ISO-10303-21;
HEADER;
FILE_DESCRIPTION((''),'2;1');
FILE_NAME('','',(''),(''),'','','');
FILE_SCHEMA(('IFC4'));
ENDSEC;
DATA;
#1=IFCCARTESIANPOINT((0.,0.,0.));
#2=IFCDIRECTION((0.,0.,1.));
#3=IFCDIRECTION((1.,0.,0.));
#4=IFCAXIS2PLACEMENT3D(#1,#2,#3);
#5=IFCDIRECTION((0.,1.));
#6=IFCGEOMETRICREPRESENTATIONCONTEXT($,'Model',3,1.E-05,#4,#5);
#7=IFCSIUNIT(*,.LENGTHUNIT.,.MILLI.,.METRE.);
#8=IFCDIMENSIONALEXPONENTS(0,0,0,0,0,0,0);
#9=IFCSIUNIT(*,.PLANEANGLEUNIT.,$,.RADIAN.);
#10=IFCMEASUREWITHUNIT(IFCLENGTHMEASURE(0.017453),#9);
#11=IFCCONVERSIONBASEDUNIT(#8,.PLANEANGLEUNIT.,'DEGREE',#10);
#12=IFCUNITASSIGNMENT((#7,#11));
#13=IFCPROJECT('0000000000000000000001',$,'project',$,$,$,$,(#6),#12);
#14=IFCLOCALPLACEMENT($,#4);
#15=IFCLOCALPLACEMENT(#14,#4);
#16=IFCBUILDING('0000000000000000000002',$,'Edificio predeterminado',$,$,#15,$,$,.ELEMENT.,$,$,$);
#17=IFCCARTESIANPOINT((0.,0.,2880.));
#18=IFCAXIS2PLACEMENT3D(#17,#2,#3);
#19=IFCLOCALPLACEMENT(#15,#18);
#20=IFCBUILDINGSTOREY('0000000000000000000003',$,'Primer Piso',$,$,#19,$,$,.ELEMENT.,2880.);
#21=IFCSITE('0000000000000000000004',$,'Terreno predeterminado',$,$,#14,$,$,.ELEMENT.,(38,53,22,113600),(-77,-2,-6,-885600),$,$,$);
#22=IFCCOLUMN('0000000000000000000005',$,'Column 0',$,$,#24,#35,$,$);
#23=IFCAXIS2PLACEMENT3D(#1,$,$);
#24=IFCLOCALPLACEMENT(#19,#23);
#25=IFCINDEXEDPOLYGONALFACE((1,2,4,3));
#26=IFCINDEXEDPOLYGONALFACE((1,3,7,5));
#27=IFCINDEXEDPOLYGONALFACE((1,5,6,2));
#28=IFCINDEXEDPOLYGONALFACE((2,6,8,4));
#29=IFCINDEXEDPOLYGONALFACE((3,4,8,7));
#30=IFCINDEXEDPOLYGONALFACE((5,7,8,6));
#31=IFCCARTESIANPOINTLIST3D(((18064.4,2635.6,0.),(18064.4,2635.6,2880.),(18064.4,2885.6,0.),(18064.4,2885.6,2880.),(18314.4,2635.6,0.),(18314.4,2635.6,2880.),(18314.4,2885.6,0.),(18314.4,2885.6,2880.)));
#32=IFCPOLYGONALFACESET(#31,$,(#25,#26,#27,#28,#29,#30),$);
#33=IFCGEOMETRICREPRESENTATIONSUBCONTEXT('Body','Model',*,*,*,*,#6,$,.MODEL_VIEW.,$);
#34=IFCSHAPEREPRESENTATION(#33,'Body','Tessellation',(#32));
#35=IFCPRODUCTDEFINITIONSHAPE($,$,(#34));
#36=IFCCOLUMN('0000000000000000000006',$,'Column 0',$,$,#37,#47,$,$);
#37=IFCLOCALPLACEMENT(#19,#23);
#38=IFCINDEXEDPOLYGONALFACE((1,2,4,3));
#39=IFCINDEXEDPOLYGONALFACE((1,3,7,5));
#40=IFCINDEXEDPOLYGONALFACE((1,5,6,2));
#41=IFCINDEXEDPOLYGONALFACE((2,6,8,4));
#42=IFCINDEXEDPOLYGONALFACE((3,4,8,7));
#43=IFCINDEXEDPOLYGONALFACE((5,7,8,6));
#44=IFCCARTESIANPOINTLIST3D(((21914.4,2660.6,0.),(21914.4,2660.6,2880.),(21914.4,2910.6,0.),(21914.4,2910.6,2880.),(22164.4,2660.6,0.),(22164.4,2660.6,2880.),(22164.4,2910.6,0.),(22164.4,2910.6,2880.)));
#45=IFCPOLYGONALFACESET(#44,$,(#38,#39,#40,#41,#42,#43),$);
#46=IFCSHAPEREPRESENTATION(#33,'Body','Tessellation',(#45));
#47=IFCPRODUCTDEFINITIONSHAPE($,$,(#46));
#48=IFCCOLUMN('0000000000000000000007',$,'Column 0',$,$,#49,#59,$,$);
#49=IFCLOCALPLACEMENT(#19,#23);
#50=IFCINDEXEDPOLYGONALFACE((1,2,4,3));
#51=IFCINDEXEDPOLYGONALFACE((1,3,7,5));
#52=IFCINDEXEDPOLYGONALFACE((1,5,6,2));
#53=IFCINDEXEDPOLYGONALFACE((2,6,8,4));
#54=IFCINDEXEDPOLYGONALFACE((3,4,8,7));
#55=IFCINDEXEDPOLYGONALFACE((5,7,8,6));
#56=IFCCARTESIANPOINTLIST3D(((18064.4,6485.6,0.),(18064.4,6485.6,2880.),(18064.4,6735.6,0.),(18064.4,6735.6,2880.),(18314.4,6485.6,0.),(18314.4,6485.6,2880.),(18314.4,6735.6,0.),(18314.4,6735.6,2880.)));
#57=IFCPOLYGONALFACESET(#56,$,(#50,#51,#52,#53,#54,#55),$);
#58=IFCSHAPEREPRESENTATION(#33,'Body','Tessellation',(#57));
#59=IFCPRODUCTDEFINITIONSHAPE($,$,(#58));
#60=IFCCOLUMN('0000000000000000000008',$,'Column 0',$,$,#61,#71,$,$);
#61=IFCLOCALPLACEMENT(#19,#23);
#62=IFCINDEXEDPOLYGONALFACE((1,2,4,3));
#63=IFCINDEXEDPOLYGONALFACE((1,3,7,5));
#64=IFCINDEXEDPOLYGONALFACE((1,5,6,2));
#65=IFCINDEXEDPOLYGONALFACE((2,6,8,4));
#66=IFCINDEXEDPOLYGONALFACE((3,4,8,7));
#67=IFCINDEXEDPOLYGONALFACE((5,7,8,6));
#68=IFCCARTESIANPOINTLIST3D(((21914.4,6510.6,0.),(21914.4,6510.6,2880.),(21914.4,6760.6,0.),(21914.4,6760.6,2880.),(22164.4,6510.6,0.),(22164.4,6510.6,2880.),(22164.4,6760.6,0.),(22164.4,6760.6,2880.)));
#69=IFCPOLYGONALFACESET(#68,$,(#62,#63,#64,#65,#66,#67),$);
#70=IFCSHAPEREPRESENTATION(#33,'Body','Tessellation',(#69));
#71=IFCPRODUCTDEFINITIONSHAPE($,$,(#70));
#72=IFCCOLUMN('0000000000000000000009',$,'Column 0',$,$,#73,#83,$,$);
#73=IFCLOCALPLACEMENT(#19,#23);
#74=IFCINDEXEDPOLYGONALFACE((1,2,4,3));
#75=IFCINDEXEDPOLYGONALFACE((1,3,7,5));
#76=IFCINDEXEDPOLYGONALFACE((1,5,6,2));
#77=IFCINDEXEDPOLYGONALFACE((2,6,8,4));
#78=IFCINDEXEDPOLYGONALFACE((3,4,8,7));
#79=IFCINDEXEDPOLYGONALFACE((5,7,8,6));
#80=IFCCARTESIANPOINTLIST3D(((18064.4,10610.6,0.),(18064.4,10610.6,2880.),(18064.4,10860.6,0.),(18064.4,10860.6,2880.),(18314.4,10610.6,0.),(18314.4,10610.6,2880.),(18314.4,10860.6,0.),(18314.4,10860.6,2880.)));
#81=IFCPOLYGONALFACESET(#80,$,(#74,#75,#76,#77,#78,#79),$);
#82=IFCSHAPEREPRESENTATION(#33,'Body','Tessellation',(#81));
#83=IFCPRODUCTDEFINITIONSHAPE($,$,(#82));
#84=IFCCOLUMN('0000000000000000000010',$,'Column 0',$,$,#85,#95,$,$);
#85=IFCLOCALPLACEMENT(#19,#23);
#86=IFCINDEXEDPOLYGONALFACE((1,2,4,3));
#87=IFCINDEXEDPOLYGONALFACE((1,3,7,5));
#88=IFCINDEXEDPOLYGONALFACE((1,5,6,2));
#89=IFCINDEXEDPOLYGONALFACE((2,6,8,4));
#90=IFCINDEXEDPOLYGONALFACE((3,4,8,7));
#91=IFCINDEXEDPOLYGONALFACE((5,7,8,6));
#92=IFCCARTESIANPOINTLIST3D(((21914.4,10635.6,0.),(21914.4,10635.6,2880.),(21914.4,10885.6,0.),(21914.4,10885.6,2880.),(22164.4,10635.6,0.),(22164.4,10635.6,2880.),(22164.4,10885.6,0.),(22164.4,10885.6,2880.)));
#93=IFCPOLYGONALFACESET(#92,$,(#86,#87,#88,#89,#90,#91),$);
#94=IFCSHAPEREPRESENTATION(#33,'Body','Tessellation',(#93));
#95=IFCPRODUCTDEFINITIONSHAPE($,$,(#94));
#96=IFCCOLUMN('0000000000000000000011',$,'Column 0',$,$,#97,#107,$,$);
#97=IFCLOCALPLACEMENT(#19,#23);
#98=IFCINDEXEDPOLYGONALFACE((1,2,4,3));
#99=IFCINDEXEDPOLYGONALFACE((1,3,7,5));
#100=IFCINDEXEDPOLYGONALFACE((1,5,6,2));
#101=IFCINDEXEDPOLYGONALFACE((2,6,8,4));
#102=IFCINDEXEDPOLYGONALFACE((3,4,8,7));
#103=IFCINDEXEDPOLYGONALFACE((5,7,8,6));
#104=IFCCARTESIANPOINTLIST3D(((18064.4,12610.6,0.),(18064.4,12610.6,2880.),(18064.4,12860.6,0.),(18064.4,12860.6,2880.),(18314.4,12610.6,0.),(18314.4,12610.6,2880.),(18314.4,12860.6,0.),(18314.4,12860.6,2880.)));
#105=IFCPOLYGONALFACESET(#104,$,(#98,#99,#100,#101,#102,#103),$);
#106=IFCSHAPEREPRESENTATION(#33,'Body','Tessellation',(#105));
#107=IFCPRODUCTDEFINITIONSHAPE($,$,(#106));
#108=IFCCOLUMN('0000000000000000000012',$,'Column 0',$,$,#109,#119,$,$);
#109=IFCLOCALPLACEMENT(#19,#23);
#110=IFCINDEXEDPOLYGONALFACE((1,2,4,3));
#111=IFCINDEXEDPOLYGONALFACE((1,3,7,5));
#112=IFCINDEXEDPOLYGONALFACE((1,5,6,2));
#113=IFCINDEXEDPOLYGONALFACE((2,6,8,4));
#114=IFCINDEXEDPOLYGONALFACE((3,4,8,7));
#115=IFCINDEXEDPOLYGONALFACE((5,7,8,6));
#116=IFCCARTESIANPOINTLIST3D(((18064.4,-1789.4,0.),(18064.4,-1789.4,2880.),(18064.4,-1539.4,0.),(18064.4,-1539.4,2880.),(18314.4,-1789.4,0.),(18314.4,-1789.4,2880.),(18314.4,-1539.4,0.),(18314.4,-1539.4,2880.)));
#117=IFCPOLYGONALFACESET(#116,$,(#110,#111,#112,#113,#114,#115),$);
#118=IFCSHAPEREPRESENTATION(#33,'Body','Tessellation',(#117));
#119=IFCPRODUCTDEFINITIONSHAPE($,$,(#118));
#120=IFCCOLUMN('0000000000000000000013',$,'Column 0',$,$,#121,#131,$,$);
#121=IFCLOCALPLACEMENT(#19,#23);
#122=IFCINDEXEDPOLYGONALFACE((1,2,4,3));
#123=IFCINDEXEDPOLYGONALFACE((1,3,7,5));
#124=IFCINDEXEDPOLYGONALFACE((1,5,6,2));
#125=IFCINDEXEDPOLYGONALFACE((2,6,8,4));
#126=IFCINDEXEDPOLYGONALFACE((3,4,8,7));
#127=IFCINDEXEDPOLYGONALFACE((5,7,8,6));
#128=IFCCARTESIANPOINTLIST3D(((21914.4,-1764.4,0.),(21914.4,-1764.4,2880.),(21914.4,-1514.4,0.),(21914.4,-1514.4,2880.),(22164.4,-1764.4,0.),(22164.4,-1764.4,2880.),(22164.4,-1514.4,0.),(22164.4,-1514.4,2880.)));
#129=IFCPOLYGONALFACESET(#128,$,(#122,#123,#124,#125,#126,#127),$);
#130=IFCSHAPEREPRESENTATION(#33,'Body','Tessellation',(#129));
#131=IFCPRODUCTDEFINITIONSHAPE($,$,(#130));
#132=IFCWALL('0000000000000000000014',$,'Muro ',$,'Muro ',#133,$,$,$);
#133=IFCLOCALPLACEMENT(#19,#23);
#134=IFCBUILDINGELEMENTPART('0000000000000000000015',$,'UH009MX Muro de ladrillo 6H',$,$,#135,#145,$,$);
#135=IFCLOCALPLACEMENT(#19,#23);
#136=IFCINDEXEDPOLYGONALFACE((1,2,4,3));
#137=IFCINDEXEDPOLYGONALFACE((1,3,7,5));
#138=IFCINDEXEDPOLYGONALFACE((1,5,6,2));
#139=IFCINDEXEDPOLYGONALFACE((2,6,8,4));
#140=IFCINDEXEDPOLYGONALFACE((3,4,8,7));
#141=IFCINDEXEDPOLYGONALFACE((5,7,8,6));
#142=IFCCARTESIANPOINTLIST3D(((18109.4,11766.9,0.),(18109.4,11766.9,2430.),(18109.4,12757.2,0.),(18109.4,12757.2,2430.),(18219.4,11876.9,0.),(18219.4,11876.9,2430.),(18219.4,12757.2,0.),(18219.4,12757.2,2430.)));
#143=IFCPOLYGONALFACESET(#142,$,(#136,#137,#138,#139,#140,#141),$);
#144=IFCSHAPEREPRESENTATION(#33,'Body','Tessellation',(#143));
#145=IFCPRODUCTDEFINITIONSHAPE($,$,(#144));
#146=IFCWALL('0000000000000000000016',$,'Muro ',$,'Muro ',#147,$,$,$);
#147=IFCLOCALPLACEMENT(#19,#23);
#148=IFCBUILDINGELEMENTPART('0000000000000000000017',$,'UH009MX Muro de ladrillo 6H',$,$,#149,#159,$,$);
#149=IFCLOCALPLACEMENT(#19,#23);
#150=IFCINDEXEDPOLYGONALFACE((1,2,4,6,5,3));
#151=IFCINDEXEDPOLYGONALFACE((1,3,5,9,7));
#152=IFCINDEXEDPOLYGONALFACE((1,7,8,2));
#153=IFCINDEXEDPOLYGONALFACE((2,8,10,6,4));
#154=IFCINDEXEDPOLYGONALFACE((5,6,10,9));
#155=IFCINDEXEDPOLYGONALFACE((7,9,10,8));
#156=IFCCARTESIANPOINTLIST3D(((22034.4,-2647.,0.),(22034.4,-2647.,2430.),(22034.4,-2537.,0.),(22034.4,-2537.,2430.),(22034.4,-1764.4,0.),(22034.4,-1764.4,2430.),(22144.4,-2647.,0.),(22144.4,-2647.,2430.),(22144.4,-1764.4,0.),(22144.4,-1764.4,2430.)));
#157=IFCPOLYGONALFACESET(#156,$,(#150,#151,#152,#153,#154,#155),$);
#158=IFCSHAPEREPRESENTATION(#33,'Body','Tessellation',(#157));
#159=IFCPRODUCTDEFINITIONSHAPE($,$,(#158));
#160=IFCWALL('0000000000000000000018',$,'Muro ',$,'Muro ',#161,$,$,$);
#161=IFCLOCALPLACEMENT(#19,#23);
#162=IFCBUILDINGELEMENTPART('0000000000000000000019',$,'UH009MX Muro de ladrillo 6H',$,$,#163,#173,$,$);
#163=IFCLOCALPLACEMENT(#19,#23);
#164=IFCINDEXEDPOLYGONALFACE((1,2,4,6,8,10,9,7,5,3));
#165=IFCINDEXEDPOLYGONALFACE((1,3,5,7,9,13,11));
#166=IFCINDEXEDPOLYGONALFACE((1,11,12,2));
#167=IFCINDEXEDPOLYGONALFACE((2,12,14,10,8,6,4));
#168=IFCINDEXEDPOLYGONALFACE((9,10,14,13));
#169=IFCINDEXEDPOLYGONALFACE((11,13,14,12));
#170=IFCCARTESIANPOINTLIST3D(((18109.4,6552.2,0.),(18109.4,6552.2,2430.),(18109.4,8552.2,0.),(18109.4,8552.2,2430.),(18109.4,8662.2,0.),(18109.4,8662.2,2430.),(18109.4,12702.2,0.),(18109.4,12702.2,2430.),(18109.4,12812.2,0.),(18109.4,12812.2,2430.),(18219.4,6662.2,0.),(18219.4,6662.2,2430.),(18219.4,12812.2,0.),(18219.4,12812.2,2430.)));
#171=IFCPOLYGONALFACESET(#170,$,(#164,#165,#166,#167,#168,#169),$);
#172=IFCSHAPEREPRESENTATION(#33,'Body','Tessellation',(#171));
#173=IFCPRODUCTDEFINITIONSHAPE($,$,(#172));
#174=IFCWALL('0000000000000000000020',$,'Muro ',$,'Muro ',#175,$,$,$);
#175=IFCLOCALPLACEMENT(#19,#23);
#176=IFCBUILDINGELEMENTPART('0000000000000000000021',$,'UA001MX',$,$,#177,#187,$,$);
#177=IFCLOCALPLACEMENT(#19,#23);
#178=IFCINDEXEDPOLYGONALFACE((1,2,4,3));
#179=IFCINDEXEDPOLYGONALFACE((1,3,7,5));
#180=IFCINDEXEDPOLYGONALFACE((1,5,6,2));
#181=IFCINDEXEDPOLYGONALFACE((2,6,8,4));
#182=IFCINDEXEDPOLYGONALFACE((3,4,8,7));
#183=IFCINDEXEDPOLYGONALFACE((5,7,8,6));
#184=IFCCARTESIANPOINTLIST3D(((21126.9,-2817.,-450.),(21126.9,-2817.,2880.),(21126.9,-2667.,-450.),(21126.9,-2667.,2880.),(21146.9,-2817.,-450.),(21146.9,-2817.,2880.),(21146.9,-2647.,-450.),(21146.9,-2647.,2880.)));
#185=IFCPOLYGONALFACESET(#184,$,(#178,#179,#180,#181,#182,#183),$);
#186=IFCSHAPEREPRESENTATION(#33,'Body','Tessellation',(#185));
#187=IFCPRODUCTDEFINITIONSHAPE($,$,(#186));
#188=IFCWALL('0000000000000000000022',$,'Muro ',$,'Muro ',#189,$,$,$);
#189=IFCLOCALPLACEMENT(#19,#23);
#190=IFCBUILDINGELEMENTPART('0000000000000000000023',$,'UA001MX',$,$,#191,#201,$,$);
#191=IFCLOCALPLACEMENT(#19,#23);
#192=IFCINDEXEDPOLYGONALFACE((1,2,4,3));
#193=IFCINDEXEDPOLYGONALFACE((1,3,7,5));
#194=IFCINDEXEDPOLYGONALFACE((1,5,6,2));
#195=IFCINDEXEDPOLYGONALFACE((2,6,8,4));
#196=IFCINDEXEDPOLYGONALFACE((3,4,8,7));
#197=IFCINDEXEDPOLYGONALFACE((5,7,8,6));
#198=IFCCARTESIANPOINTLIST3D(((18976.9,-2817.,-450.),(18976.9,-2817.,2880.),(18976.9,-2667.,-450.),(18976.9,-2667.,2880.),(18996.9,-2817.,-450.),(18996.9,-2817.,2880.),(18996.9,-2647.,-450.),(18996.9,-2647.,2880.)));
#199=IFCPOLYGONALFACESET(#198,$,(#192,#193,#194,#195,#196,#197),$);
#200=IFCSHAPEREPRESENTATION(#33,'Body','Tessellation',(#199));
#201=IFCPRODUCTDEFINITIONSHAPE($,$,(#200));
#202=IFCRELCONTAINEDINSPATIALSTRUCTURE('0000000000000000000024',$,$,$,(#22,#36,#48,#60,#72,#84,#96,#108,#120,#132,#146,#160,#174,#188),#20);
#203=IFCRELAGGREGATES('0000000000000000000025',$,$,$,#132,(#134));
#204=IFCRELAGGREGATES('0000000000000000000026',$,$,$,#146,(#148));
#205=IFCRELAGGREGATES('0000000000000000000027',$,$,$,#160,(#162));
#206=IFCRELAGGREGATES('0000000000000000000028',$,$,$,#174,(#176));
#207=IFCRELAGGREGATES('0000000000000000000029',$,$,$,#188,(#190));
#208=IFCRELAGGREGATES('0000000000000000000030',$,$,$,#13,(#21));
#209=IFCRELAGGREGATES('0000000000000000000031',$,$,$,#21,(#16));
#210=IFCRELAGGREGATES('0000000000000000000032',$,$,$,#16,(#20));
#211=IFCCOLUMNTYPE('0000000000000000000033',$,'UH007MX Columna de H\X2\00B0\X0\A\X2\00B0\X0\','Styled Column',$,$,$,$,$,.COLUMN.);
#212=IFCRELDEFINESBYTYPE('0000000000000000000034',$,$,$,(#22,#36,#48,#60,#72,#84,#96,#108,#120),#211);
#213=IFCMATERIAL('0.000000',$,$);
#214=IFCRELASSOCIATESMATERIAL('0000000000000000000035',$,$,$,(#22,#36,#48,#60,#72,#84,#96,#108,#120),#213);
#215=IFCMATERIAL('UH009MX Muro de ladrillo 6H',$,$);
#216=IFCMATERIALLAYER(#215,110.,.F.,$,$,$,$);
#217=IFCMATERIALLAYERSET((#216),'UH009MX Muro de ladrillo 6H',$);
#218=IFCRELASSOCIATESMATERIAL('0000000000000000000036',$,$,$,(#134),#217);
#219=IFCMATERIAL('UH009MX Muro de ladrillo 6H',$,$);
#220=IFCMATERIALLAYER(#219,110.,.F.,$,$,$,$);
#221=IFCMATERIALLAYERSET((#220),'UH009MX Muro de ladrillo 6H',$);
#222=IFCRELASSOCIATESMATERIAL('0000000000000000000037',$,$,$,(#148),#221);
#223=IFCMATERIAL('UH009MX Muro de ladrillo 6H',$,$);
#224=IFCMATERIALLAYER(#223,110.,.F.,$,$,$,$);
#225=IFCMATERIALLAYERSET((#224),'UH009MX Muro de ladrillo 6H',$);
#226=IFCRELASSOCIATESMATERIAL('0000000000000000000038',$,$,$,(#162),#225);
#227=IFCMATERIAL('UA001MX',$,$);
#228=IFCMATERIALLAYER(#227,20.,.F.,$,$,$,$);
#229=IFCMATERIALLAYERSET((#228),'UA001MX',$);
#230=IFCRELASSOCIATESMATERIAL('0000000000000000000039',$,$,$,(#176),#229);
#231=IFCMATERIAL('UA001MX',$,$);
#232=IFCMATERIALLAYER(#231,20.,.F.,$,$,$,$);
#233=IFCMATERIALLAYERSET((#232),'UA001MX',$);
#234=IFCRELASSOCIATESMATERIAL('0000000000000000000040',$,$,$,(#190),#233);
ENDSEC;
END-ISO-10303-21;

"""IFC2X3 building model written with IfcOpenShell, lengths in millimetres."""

from ifc_helpers import new_model, entity, si_unit, converted_unit, direction, frame, origin_with_axes, place, context, subcontext, project, spatial, polyline, outline, extrude, clip, bounded_halfspace, material, layer, layer_set, layer_usage, type_object, element, aggregate, save


model = new_model("IFC2X3")

# Units and contexts
model_context = context("Model", 3, precision=1e-05, world=origin_with_axes(), true_north=direction((0.0, 1.0)))
body_context = subcontext(model_context, "Body", "Model", "MODEL_VIEW")
ifc_project = project(units=[si_unit("LENGTHUNIT", "METRE", prefix="MILLI"), converted_unit("PLANEANGLEUNIT", "DEGREE", entity("IfcLengthMeasure", 0.017453), si_unit("PLANEANGLEUNIT", "RADIAN"), dimensions=[0, 0, 0, 0, 0, 0, 0])], contexts=[model_context])

# Site, building, storey
site_placement = place(None, origin_with_axes())
site = spatial("IfcSite", under=ifc_project, at=site_placement, Name="Terreno predeterminado", CompositionType="ELEMENT", RefLatitude=(38, 53, 22, 113600), RefLongitude=(-77, -2, -6, -885600))
building_placement = place(site_placement, origin_with_axes())
building = spatial("IfcBuilding", under=site, at=building_placement, Name="Edificio predeterminado", CompositionType="ELEMENT")
storey_placement = place(building_placement, frame((0.0, 0.0, 2880.0), z_axis=(0.0, 0.0, 1.0), x_axis=(1.0, 0.0, 0.0)))
storey = spatial("IfcBuildingStorey", under=building, at=storey_placement, Name="Primer Piso", CompositionType="ELEMENT", Elevation=2880.0)

# Columns
ifc_material_1 = material(Name="0.000000")
column_type = type_object("IfcColumnType", Name="UH007MX Columna de H°A°", Description="Styled Column", PredefinedType="COLUMN")
for number, where, z_axis, x_axis, name in (
    (1, (18189.4, 2760.6, 0.0), (0.0, 0.0, 1.0), (1.0, 0.0, 0.0), "Column 0"),
    (2, (22039.4, 2785.6, 0.0), (0.0, 0.0, 1.0), (1.0, 0.0, 0.0), "Column 0"),
    (3, (18189.4, 6610.6, 0.0), (0.0, 0.0, 1.0), (1.0, 0.0, 0.0), "Column 0"),
    (4, (22039.4, 6635.6, 0.0), (0.0, 0.0, 1.0), (1.0, 0.0, 0.0), "Column 0"),
    (5, (18189.4, 10735.6, 0.0), (0.0, 0.0, 1.0), (1.0, 0.0, 0.0), "Column 0"),
    (6, (22039.4, 10760.6, 0.0), (0.0, 0.0, 1.0), (1.0, 0.0, 0.0), "Column 0"),
    (7, (18189.4, 12735.6, 0.0), (0.0, 0.0, 1.0), (1.0, 0.0, 0.0), "Column 0"),
    (8, (18189.4, -1664.4, 0.0), (0.0, 0.0, 1.0), (1.0, 0.0, 0.0), "Column 0"),
    (9, (22039.4, -1639.4, 0.0), (0.0, 0.0, 1.0), (1.0, 0.0, 0.0), "Column 0"),
):
    element("IfcColumn", number, at=place(storey_placement, frame(where, z_axis=z_axis, x_axis=x_axis)), inside=storey, type_object=column_type, material=ifc_material_1, Name=name, context=body_context, shape_type="SweptSolid", body=[
        extrude(outline(polyline([(-125.0, -125.0), (125.0, -125.0), (125.0, 125.0), (-125.0, 125.0), (-125.0, -125.0)])), origin_with_axes(), (0.0, 0.0, 1.0), 2880.0),
    ])

# Walls, building element parts
wall_1_placement = place(storey_placement, frame((18164.4, 11821.9, 0.0), z_axis=(0.0, 0.0, 1.0), x_axis=(0.0, 1.0, 0.0)))
wall_1 = element("IfcWall", 10, at=wall_1_placement, inside=storey, Name="Muro ", ObjectType="Muro ")
ifc_material_2 = material(Name="UH009MX Muro de ladrillo 6H")
ifc_layer_1 = layer(ifc_material_2, 110.0, ventilated=False)
ifc_layer_set_1 = layer_set([ifc_layer_1], Name="UH009MX Muro de ladrillo 6H")
ifc_layer_usage_1 = layer_usage(ifc_layer_set_1, "AXIS2", "NEGATIVE", -55.0)
building_element_part_1_placement = place(wall_1_placement, origin_with_axes())
building_element_part_1 = element("IfcBuildingElementPart", 11, at=building_element_part_1_placement, material=ifc_layer_usage_1, Name="UH009MX Muro de ladrillo 6H", context=body_context, shape_type="SweptSolid", body=[
    extrude(outline(polyline([(935.2, 55.0), (935.2, -55.0), (55.0, -55.0), (-55.0, 55.0), (935.2, 55.0)])), origin_with_axes(), (0.0, 0.0, 1.0), 2430.0),
])
aggregate(wall_1, [building_element_part_1])
wall_2_placement = place(storey_placement, frame((22089.4, -1764.4, 0.0), z_axis=(0.0, 0.0, 1.0), x_axis=(0.0, -1.0, 0.0)))
wall_2 = element("IfcWall", 12, at=wall_2_placement, inside=storey, Name="Muro ", ObjectType="Muro ")
ifc_material_3 = material(Name="UH009MX Muro de ladrillo 6H")
ifc_layer_2 = layer(ifc_material_3, 110.0, ventilated=False)
ifc_layer_set_2 = layer_set([ifc_layer_2], Name="UH009MX Muro de ladrillo 6H")
ifc_layer_usage_2 = layer_usage(ifc_layer_set_2, "AXIS2", "NEGATIVE", -55.0)
building_element_part_2_placement = place(wall_2_placement, origin_with_axes())
building_element_part_2 = element("IfcBuildingElementPart", 13, at=building_element_part_2_placement, material=ifc_layer_usage_2, Name="UH009MX Muro de ladrillo 6H", context=body_context, shape_type="SweptSolid", body=[
    extrude(outline(polyline([(882.6, 55.0), (882.6, -55.0), (772.6, -55.0), (0.0, -55.0), (0.0, 55.0), (882.6, 55.0)])), origin_with_axes(), (0.0, 0.0, 1.0), 2430.0),
])
aggregate(wall_2, [building_element_part_2])
wall_3_placement = place(storey_placement, frame((18164.4, 12757.2, 0.0), z_axis=(0.0, 0.0, 1.0), x_axis=(0.0, -1.0, 0.0)))
wall_3 = element("IfcWall", 14, at=wall_3_placement, inside=storey, Name="Muro ", ObjectType="Muro ")
ifc_material_4 = material(Name="UH009MX Muro de ladrillo 6H")
ifc_layer_3 = layer(ifc_material_4, 110.0, ventilated=False)
ifc_layer_set_3 = layer_set([ifc_layer_3], Name="UH009MX Muro de ladrillo 6H")
ifc_layer_usage_3 = layer_usage(ifc_layer_set_3, "AXIS2", "NEGATIVE", -55.0)
building_element_part_3_placement = place(wall_3_placement, origin_with_axes())
building_element_part_3 = element("IfcBuildingElementPart", 15, at=building_element_part_3_placement, material=ifc_layer_usage_3, Name="UH009MX Muro de ladrillo 6H", context=body_context, shape_type="SweptSolid", body=[
    extrude(outline(polyline([(6095.0, 55.0), (6205.0, -55.0), (4205.0, -55.0), (4095.0, -55.0), (55.0, -55.0), (-55.0, -55.0), (-55.0, 55.0), (6095.0, 55.0)])), origin_with_axes(), (0.0, 0.0, 1.0), 2430.0),
])
aggregate(wall_3, [building_element_part_3])
wall_4_placement = place(storey_placement, frame((21201.9, -2817.0, 0.0), z_axis=(0.0, 0.0, 1.0), x_axis=(0.0, 1.0, 0.0)))
wall_4 = element("IfcWall", 16, at=wall_4_placement, inside=storey, Name="Muro ", ObjectType="Muro ")
ifc_material_5 = material(Name="UA001MX")
ifc_layer_4 = layer(ifc_material_5, 20.0, ventilated=False)
ifc_layer_set_4 = layer_set([ifc_layer_4], Name="UA001MX")
ifc_layer_usage_4 = layer_usage(ifc_layer_set_4, "AXIS2", "NEGATIVE", -75.0)
building_element_part_4_placement = place(wall_4_placement, origin_with_axes())
building_element_part_4 = element("IfcBuildingElementPart", 17, at=building_element_part_4_placement, material=ifc_layer_usage_4, Name="UA001MX", context=body_context, shape_type="Clipping", body=[
    clip(clip(extrude(outline(polyline([(150.0, 75.0), (170.0, 55.0), (0.0, 55.0), (0.0, 75.0), (150.0, 75.0)])), frame((0.0, 0.0, -450.0), z_axis=(0.0, 0.0, 1.0), x_axis=(1.0, 0.0, 0.0)), (0.0, 0.0, 1.0), 3330.0), bounded_halfspace(frame((0.0, 0.0, -450.0), z_axis=(0.0, 0.0, 1.0), x_axis=(1.0, 0.0, 0.0)), True, origin_with_axes(), polyline([(-150.0, -150.0), (375.0, -150.0), (375.0, 150.0), (-150.0, 150.0), (-150.0, -150.0)]))), bounded_halfspace(frame((0.0, 0.0, 2880.0), z_axis=(0.0, 0.0, 1.0), x_axis=(1.0, 0.0, 0.0)), False, origin_with_axes(), polyline([(-150.0, -150.0), (375.0, -150.0), (375.0, 150.0), (-150.0, 150.0), (-150.0, -150.0)]))),
])
aggregate(wall_4, [building_element_part_4])
wall_5_placement = place(storey_placement, frame((19051.9, -2817.0, 0.0), z_axis=(0.0, 0.0, 1.0), x_axis=(0.0, 1.0, 0.0)))
wall_5 = element("IfcWall", 18, at=wall_5_placement, inside=storey, Name="Muro ", ObjectType="Muro ")
ifc_material_6 = material(Name="UA001MX")
ifc_layer_5 = layer(ifc_material_6, 20.0, ventilated=False)
ifc_layer_set_5 = layer_set([ifc_layer_5], Name="UA001MX")
ifc_layer_usage_5 = layer_usage(ifc_layer_set_5, "AXIS2", "NEGATIVE", -75.0)
building_element_part_5_placement = place(wall_5_placement, origin_with_axes())
building_element_part_5 = element("IfcBuildingElementPart", 19, at=building_element_part_5_placement, material=ifc_layer_usage_5, Name="UA001MX", context=body_context, shape_type="Clipping", body=[
    clip(clip(extrude(outline(polyline([(150.0, 75.0), (170.0, 55.0), (0.0, 55.0), (0.0, 75.0), (150.0, 75.0)])), frame((0.0, 0.0, -450.0), z_axis=(0.0, 0.0, 1.0), x_axis=(1.0, 0.0, 0.0)), (0.0, 0.0, 1.0), 3330.0), bounded_halfspace(frame((0.0, 0.0, -450.0), z_axis=(0.0, 0.0, 1.0), x_axis=(1.0, 0.0, 0.0)), True, origin_with_axes(), polyline([(-150.0, -150.0), (375.0, -150.0), (375.0, 150.0), (-150.0, 150.0), (-150.0, -150.0)]))), bounded_halfspace(frame((0.0, 0.0, 2880.0), z_axis=(0.0, 0.0, 1.0), x_axis=(1.0, 0.0, 0.0)), False, origin_with_axes(), polyline([(-150.0, -150.0), (375.0, -150.0), (375.0, 150.0), (-150.0, 150.0), (-150.0, -150.0)]))),
])
aggregate(wall_5, [building_element_part_5])

save(model, "model.ifc")
